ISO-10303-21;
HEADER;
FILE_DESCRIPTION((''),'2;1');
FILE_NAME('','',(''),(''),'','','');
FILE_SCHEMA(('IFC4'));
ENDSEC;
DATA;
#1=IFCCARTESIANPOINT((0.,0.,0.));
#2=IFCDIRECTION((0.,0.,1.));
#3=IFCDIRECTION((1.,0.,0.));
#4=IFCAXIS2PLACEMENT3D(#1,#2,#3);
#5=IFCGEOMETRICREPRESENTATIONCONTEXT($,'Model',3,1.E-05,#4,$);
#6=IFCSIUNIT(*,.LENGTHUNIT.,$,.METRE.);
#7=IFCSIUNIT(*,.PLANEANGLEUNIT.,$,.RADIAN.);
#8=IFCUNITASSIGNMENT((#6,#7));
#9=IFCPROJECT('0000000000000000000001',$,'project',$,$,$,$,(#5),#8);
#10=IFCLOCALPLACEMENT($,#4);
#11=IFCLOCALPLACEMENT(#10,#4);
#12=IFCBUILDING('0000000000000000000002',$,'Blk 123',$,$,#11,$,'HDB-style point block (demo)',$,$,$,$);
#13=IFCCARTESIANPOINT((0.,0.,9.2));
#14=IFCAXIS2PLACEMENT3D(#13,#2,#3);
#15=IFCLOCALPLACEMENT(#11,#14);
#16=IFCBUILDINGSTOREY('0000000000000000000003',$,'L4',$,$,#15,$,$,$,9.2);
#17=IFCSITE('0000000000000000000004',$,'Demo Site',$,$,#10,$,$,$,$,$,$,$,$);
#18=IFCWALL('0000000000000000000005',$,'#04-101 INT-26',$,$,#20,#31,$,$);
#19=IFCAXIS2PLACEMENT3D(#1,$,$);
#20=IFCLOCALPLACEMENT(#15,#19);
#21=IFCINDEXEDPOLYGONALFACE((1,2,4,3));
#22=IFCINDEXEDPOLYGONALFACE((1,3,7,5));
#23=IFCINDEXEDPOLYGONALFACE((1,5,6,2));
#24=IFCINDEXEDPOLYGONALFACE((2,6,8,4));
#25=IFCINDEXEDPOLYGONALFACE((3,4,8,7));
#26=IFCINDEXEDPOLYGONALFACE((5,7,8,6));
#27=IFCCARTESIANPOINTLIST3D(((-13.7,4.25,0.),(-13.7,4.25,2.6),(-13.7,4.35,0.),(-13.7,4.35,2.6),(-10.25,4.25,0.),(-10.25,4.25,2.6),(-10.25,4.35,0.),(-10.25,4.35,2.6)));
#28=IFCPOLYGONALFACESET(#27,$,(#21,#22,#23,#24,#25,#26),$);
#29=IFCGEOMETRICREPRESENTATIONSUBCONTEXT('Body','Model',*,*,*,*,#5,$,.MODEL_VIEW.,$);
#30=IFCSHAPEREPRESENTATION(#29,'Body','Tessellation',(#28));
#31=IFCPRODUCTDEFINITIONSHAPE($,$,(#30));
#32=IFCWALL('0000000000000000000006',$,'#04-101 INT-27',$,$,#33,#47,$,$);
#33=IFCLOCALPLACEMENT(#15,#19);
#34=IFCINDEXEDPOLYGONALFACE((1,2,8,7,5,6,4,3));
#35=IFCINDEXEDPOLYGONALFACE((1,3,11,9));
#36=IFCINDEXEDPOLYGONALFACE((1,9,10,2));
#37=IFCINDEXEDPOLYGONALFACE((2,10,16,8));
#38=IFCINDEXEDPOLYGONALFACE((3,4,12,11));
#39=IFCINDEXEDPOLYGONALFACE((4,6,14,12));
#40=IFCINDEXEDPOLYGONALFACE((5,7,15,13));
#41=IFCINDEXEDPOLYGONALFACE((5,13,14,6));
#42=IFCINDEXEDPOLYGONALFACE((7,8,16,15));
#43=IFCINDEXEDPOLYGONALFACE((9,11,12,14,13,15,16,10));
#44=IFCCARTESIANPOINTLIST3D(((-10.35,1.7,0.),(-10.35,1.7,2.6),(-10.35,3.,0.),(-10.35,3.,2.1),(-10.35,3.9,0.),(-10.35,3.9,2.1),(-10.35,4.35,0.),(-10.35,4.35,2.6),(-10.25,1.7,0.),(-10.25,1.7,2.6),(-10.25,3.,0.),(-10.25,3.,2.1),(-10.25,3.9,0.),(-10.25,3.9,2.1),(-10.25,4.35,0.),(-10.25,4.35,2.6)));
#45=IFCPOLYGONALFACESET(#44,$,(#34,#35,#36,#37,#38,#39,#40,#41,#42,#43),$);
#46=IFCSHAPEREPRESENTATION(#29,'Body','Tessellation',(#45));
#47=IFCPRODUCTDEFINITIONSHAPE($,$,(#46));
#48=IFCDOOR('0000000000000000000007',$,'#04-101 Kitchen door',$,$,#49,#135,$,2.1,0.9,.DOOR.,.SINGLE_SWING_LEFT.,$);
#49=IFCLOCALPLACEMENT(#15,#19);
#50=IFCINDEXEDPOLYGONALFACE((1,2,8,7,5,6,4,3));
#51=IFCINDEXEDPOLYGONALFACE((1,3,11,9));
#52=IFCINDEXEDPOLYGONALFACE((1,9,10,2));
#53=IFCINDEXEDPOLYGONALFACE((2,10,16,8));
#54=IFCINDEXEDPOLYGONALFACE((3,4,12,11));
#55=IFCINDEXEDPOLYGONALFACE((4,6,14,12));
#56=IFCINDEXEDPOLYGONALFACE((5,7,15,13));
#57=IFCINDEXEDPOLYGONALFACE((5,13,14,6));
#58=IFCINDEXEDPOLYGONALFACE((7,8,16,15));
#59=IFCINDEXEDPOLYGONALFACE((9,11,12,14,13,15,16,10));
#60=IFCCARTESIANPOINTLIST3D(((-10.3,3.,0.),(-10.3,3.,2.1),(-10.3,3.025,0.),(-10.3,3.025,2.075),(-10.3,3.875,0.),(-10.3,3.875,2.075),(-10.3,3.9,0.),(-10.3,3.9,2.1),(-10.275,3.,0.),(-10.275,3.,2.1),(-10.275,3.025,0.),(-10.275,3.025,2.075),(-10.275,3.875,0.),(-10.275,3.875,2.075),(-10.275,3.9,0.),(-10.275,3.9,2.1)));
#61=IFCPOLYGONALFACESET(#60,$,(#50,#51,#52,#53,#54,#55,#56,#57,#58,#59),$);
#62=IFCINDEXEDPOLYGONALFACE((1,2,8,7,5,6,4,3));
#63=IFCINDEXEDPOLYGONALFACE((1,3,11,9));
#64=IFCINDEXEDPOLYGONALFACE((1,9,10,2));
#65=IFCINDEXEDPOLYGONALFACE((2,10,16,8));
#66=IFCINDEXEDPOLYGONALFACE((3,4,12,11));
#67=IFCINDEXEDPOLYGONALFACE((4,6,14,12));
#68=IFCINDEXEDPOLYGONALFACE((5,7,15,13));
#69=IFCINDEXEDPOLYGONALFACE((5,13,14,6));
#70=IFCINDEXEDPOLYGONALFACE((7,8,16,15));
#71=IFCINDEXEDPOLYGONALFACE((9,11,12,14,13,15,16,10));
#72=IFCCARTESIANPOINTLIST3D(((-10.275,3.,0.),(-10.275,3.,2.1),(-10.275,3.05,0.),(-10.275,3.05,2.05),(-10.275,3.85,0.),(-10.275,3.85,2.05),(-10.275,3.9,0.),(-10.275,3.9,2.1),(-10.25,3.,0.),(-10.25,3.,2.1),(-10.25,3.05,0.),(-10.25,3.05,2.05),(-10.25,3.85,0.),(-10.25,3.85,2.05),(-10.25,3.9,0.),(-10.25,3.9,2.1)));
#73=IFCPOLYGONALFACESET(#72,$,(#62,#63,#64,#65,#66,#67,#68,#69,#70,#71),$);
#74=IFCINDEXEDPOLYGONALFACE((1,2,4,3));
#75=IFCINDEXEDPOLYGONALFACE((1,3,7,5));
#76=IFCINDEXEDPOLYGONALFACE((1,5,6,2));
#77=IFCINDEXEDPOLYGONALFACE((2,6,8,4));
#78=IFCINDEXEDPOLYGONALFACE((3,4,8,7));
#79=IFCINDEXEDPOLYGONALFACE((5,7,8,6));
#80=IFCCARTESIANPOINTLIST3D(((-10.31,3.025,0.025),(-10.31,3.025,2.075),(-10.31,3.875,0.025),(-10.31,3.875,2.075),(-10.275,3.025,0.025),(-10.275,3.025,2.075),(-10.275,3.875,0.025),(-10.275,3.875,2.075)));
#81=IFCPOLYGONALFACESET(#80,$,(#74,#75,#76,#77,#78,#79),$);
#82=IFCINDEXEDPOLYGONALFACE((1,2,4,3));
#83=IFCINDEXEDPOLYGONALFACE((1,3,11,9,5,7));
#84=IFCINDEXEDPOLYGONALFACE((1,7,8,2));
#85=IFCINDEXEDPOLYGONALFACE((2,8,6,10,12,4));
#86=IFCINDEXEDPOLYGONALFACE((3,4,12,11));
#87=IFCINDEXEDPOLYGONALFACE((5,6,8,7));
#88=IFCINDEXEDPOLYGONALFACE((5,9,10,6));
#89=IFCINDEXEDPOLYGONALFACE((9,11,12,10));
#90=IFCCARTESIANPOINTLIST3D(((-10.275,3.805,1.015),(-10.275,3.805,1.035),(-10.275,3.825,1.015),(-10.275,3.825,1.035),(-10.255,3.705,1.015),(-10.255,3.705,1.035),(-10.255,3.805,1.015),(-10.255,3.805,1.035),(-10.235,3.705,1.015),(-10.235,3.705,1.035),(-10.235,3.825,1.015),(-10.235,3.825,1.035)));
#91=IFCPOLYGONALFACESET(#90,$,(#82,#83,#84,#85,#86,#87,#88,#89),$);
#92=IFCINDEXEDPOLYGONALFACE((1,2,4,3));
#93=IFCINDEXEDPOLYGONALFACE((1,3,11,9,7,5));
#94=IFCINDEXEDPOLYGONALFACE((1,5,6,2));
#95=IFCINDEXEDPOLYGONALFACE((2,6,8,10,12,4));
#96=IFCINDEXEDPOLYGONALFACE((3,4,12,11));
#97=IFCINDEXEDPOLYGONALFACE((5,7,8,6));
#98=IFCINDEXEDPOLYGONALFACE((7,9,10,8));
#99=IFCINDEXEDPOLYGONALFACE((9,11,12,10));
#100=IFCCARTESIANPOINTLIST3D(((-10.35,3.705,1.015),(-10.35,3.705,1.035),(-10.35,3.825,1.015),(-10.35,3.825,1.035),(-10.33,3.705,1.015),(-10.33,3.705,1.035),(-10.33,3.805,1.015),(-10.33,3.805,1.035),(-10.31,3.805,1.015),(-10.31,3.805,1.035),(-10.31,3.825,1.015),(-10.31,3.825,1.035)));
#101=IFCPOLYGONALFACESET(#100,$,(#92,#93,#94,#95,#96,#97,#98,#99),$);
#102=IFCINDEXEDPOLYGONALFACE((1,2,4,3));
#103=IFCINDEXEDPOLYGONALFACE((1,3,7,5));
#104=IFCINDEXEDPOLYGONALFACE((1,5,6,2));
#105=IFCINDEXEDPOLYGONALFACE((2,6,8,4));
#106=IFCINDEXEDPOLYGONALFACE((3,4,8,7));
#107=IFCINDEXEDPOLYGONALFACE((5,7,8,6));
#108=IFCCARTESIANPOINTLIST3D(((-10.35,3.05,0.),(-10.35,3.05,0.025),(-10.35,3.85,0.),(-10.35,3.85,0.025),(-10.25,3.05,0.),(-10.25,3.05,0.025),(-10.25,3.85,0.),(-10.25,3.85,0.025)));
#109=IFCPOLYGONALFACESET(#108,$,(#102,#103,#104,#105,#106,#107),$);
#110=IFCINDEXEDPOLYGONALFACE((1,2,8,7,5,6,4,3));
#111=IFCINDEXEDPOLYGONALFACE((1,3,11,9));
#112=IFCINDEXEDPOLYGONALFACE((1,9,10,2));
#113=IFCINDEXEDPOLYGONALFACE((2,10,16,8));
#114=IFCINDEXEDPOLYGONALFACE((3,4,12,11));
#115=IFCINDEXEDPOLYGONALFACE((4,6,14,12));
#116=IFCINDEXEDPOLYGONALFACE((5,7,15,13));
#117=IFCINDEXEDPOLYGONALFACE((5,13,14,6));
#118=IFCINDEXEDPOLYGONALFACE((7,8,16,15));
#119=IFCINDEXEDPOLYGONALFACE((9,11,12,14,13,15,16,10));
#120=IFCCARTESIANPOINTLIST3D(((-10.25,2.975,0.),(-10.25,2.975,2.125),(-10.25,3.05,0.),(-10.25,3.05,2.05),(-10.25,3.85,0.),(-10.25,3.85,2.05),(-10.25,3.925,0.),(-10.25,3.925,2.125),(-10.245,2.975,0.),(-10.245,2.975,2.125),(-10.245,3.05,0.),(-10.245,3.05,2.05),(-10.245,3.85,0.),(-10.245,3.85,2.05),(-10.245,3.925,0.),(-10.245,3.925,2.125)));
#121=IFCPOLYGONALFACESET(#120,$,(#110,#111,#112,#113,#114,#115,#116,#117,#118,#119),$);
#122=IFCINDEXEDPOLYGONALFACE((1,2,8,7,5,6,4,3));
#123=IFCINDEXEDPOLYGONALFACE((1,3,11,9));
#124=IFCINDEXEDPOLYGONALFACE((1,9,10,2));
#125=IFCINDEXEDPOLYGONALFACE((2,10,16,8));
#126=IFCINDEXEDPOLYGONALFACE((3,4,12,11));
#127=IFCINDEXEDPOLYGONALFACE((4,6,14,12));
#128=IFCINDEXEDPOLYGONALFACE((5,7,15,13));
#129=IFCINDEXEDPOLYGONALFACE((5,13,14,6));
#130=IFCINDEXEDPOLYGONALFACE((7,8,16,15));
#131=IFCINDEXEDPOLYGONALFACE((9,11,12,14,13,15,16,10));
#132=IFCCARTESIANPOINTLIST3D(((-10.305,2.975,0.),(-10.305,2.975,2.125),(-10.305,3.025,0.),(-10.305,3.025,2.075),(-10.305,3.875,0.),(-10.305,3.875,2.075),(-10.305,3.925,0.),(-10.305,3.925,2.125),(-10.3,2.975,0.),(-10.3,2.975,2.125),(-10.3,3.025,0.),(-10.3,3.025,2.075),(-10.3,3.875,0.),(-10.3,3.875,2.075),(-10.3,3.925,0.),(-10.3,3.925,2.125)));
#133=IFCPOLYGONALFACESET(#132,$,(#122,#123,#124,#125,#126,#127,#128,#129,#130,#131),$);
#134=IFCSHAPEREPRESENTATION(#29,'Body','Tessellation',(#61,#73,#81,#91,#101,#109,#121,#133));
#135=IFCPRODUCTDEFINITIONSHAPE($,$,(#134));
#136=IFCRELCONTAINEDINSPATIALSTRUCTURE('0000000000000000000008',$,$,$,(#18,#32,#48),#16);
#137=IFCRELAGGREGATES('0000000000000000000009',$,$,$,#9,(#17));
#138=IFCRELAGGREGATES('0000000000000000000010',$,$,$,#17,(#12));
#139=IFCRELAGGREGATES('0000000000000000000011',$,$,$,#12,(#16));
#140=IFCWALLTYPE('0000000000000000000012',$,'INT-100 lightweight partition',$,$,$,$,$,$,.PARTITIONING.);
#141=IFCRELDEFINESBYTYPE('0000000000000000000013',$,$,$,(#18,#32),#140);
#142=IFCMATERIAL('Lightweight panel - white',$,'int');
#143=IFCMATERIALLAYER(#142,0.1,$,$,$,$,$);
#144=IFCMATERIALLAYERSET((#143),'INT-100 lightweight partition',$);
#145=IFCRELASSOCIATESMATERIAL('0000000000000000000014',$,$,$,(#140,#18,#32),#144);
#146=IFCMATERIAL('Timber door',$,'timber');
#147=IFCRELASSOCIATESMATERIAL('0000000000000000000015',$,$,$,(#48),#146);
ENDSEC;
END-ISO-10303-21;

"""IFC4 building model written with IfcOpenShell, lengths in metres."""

from ifc_helpers import new_model, si_unit, frame, origin_with_axes, place, context, subcontext, project, spatial, line, indexed_curve, outline, extrude, material, layer, layer_set, layer_usage, type_object, element, fill, save


model = new_model("IFC4")

# Units and contexts
model_context = context("Model", 3, precision=1e-05, world=origin_with_axes())
body_context = subcontext(model_context, "Body", "Model", "MODEL_VIEW")
ifc_project = project(units=[si_unit("LENGTHUNIT", "METRE"), si_unit("PLANEANGLEUNIT", "RADIAN")], contexts=[model_context])

# Site, building, storey
site_placement = place(None, origin_with_axes())
site = spatial("IfcSite", under=ifc_project, at=site_placement, Name="Demo Site")
building_placement = place(site_placement, origin_with_axes())
building = spatial("IfcBuilding", under=site, at=building_placement, Name="Blk 123", LongName="HDB-style point block (demo)")
storey_placement = place(building_placement, frame((0.0, 0.0, 9.2), z_axis=(0.0, 0.0, 1.0), x_axis=(1.0, 0.0, 0.0)))
storey = spatial("IfcBuildingStorey", under=building, at=storey_placement, Name="L4", Elevation=9.2)

# Shared definitions
ifc_material_1 = material(Name="Timber door", Category="timber")

# Wall
ifc_material_2 = material(Name="Lightweight panel - white", Category="int")
ifc_layer_1 = layer(ifc_material_2, 0.1)
ifc_layer_set_1 = layer_set([ifc_layer_1], Name="INT-100 lightweight partition")
ifc_layer_usage_1 = layer_usage(ifc_layer_set_1, "AXIS2", "POSITIVE", -0.05)
wall_type_1 = type_object("IfcWallType", Name="INT-100 lightweight partition", PredefinedType="PARTITIONING", material=ifc_layer_set_1)
wall_1_placement = place(storey_placement, frame((-10.25, 4.3, 0.0), z_axis=(0.0, 0.0, 1.0), x_axis=(-1.0, 0.0, 0.0)))
element("IfcWall", 1, at=wall_1_placement, inside=storey, type_object=wall_type_1, material=ifc_layer_usage_1, Name="#04-101 INT-26", context=body_context, shape_type="SweptSolid", body=[
    extrude(outline(indexed_curve([(0.0, 0.0), (0.0, 0.1), (3.45, 0.1), (3.45, 0.0), (0.0, 0.0)], self_intersect=False)), frame((0.0, -0.05, 0.0), z_axis=(0.0, 0.0, 1.0), x_axis=(1.0, 0.0, 0.0)), (0.0, 0.0, 1.0), 2.6),
])

# Wall, opening, door
wall_2_placement = place(storey_placement, frame((-10.3, 1.7, 0.0), z_axis=(0.0, 0.0, 1.0), x_axis=(0.0, 1.0, 0.0)))
wall_2 = element("IfcWall", 2, at=wall_2_placement, inside=storey, type_object=wall_type_1, material=ifc_layer_usage_1, Name="#04-101 INT-27", context=body_context, shape_type="SweptSolid", body=[
    extrude(outline(indexed_curve([(0.0, 0.0), (0.0, 0.1), (2.65, 0.1), (2.65, 0.0), (0.0, 0.0)], self_intersect=False)), frame((0.0, -0.05, 0.0), z_axis=(0.0, 0.0, 1.0), x_axis=(1.0, 0.0, 0.0)), (0.0, 0.0, 1.0), 2.6),
])
opening_1_placement = place(wall_2_placement, frame((1.3, -0.15, 0.0), z_axis=(0.0, 0.0, 1.0), x_axis=(1.0, 0.0, 0.0)))
opening_1 = element("IfcOpeningElement", 3, at=opening_1_placement, cuts=wall_2, context=body_context, shape_type="SweptSolid", body=[
    extrude(outline(indexed_curve([(0.0, 0.0), (0.0, 0.3), (0.9, 0.3), (0.9, 0.0), (0.0, 0.0)], self_intersect=False)), origin_with_axes(), (0.0, 0.0, 1.0), 2.1),
])
door_1_placement = place(opening_1_placement, frame((0.0, 0.1, 0.0), z_axis=(0.0, 0.0, 1.0), x_axis=(1.0, 0.0, 0.0)))
door_1 = element("IfcDoor", 4, at=door_1_placement, inside=storey, material=ifc_material_1, Name="#04-101 Kitchen door", OperationType="SINGLE_SWING_LEFT", OverallHeight=2.1, OverallWidth=0.9, PredefinedType="DOOR", context=body_context, shape_type="SweptSolid", body=[
    extrude(outline(indexed_curve([(0.0, 0.0), (0.0, 2.1), (0.9, 2.1), (0.9, 0.0), (0.875, 0.0), (0.875, 2.075), (0.025, 2.075), (0.025, 0.0)], segments=[line(1, 2, 3, 4, 5, 6, 7, 8, 1)])), frame((0.0, 0.025, 0.0), z_axis=(0.0, -1.0, 0.0), x_axis=(1.0, 0.0, 0.0)), (0.0, 0.0, -1.0), 0.025),
    extrude(outline(indexed_curve([(0.0, 0.0), (0.0, 2.1), (0.9, 2.1), (0.9, 0.0), (0.85, 0.0), (0.85, 2.05), (0.05, 2.05), (0.05, 0.0)], segments=[line(1, 2, 3, 4, 5, 6, 7, 8, 1)])), frame((0.0, 0.0, 0.0), z_axis=(0.0, -1.0, 0.0), x_axis=(1.0, 0.0, 0.0)), (0.0, 0.0, -1.0), 0.025),
    extrude(outline(indexed_curve([(0.0, 0.0), (0.85, 0.0), (0.85, 0.035), (0.0, 0.035)], segments=[line(1, 2, 3, 4, 1)])), frame((0.025, 0.025, 0.025), z_axis=(0.0, 0.0, 1.0), x_axis=(1.0, 0.0, 0.0)), (0.0, 0.0, 1.0), 2.05),
    extrude(outline(indexed_curve([(0.0, 0.0), (0.0, -0.04), (-0.12, -0.04), (-0.12, -0.02), (-0.02, -0.02), (-0.02, 0.0)], segments=[line(1, 2, 3, 4, 5, 6, 1)])), frame((0.825, 0.025, 1.015), z_axis=(0.0, 0.0, 1.0), x_axis=(1.0, 0.0, 0.0)), (0.0, 0.0, 1.0), 0.02),
    extrude(outline(indexed_curve([(0.0, 0.0), (0.0, 0.04), (-0.12, 0.04), (-0.12, 0.02), (-0.02, 0.02), (-0.02, 0.0)], segments=[line(1, 2, 3, 4, 5, 6, 1)])), frame((0.825, 0.06, 1.015), z_axis=(0.0, 0.0, 1.0), x_axis=(1.0, 0.0, 0.0)), (0.0, 0.0, 1.0), 0.02),
    extrude(outline(indexed_curve([(0.0, 0.0), (0.8, 0.0), (0.8, 0.1), (0.0, 0.1)], segments=[line(1, 2, 3, 4, 1)])), frame((0.05, 0.0, 0.0), z_axis=(0.0, 0.0, 1.0), x_axis=(1.0, 0.0, 0.0)), (0.0, 0.0, 1.0), 0.025),
    extrude(outline(indexed_curve([(0.0, 0.0), (0.0, 2.125), (0.95, 2.125), (0.95, 0.0), (0.875, 0.0), (0.875, 2.05), (0.075, 2.05), (0.075, 0.0)], segments=[line(1, 2, 3, 4, 5, 6, 7, 8, 1)])), frame((-0.025, -0.005, 0.0), z_axis=(0.0, -1.0, 0.0), x_axis=(1.0, 0.0, 0.0)), (0.0, 0.0, -1.0), 0.005),
    extrude(outline(indexed_curve([(0.0, 0.0), (0.0, 2.125), (0.95, 2.125), (0.95, 0.0), (0.9, 0.0), (0.9, 2.075), (0.05, 2.075), (0.05, 0.0)], segments=[line(1, 2, 3, 4, 5, 6, 7, 8, 1)])), frame((-0.025, 0.05, 0.0), z_axis=(0.0, -1.0, 0.0), x_axis=(1.0, 0.0, 0.0)), (0.0, 0.0, -1.0), 0.005),
])
fill(opening_1, door_1)

save(model, "model.ifc")
